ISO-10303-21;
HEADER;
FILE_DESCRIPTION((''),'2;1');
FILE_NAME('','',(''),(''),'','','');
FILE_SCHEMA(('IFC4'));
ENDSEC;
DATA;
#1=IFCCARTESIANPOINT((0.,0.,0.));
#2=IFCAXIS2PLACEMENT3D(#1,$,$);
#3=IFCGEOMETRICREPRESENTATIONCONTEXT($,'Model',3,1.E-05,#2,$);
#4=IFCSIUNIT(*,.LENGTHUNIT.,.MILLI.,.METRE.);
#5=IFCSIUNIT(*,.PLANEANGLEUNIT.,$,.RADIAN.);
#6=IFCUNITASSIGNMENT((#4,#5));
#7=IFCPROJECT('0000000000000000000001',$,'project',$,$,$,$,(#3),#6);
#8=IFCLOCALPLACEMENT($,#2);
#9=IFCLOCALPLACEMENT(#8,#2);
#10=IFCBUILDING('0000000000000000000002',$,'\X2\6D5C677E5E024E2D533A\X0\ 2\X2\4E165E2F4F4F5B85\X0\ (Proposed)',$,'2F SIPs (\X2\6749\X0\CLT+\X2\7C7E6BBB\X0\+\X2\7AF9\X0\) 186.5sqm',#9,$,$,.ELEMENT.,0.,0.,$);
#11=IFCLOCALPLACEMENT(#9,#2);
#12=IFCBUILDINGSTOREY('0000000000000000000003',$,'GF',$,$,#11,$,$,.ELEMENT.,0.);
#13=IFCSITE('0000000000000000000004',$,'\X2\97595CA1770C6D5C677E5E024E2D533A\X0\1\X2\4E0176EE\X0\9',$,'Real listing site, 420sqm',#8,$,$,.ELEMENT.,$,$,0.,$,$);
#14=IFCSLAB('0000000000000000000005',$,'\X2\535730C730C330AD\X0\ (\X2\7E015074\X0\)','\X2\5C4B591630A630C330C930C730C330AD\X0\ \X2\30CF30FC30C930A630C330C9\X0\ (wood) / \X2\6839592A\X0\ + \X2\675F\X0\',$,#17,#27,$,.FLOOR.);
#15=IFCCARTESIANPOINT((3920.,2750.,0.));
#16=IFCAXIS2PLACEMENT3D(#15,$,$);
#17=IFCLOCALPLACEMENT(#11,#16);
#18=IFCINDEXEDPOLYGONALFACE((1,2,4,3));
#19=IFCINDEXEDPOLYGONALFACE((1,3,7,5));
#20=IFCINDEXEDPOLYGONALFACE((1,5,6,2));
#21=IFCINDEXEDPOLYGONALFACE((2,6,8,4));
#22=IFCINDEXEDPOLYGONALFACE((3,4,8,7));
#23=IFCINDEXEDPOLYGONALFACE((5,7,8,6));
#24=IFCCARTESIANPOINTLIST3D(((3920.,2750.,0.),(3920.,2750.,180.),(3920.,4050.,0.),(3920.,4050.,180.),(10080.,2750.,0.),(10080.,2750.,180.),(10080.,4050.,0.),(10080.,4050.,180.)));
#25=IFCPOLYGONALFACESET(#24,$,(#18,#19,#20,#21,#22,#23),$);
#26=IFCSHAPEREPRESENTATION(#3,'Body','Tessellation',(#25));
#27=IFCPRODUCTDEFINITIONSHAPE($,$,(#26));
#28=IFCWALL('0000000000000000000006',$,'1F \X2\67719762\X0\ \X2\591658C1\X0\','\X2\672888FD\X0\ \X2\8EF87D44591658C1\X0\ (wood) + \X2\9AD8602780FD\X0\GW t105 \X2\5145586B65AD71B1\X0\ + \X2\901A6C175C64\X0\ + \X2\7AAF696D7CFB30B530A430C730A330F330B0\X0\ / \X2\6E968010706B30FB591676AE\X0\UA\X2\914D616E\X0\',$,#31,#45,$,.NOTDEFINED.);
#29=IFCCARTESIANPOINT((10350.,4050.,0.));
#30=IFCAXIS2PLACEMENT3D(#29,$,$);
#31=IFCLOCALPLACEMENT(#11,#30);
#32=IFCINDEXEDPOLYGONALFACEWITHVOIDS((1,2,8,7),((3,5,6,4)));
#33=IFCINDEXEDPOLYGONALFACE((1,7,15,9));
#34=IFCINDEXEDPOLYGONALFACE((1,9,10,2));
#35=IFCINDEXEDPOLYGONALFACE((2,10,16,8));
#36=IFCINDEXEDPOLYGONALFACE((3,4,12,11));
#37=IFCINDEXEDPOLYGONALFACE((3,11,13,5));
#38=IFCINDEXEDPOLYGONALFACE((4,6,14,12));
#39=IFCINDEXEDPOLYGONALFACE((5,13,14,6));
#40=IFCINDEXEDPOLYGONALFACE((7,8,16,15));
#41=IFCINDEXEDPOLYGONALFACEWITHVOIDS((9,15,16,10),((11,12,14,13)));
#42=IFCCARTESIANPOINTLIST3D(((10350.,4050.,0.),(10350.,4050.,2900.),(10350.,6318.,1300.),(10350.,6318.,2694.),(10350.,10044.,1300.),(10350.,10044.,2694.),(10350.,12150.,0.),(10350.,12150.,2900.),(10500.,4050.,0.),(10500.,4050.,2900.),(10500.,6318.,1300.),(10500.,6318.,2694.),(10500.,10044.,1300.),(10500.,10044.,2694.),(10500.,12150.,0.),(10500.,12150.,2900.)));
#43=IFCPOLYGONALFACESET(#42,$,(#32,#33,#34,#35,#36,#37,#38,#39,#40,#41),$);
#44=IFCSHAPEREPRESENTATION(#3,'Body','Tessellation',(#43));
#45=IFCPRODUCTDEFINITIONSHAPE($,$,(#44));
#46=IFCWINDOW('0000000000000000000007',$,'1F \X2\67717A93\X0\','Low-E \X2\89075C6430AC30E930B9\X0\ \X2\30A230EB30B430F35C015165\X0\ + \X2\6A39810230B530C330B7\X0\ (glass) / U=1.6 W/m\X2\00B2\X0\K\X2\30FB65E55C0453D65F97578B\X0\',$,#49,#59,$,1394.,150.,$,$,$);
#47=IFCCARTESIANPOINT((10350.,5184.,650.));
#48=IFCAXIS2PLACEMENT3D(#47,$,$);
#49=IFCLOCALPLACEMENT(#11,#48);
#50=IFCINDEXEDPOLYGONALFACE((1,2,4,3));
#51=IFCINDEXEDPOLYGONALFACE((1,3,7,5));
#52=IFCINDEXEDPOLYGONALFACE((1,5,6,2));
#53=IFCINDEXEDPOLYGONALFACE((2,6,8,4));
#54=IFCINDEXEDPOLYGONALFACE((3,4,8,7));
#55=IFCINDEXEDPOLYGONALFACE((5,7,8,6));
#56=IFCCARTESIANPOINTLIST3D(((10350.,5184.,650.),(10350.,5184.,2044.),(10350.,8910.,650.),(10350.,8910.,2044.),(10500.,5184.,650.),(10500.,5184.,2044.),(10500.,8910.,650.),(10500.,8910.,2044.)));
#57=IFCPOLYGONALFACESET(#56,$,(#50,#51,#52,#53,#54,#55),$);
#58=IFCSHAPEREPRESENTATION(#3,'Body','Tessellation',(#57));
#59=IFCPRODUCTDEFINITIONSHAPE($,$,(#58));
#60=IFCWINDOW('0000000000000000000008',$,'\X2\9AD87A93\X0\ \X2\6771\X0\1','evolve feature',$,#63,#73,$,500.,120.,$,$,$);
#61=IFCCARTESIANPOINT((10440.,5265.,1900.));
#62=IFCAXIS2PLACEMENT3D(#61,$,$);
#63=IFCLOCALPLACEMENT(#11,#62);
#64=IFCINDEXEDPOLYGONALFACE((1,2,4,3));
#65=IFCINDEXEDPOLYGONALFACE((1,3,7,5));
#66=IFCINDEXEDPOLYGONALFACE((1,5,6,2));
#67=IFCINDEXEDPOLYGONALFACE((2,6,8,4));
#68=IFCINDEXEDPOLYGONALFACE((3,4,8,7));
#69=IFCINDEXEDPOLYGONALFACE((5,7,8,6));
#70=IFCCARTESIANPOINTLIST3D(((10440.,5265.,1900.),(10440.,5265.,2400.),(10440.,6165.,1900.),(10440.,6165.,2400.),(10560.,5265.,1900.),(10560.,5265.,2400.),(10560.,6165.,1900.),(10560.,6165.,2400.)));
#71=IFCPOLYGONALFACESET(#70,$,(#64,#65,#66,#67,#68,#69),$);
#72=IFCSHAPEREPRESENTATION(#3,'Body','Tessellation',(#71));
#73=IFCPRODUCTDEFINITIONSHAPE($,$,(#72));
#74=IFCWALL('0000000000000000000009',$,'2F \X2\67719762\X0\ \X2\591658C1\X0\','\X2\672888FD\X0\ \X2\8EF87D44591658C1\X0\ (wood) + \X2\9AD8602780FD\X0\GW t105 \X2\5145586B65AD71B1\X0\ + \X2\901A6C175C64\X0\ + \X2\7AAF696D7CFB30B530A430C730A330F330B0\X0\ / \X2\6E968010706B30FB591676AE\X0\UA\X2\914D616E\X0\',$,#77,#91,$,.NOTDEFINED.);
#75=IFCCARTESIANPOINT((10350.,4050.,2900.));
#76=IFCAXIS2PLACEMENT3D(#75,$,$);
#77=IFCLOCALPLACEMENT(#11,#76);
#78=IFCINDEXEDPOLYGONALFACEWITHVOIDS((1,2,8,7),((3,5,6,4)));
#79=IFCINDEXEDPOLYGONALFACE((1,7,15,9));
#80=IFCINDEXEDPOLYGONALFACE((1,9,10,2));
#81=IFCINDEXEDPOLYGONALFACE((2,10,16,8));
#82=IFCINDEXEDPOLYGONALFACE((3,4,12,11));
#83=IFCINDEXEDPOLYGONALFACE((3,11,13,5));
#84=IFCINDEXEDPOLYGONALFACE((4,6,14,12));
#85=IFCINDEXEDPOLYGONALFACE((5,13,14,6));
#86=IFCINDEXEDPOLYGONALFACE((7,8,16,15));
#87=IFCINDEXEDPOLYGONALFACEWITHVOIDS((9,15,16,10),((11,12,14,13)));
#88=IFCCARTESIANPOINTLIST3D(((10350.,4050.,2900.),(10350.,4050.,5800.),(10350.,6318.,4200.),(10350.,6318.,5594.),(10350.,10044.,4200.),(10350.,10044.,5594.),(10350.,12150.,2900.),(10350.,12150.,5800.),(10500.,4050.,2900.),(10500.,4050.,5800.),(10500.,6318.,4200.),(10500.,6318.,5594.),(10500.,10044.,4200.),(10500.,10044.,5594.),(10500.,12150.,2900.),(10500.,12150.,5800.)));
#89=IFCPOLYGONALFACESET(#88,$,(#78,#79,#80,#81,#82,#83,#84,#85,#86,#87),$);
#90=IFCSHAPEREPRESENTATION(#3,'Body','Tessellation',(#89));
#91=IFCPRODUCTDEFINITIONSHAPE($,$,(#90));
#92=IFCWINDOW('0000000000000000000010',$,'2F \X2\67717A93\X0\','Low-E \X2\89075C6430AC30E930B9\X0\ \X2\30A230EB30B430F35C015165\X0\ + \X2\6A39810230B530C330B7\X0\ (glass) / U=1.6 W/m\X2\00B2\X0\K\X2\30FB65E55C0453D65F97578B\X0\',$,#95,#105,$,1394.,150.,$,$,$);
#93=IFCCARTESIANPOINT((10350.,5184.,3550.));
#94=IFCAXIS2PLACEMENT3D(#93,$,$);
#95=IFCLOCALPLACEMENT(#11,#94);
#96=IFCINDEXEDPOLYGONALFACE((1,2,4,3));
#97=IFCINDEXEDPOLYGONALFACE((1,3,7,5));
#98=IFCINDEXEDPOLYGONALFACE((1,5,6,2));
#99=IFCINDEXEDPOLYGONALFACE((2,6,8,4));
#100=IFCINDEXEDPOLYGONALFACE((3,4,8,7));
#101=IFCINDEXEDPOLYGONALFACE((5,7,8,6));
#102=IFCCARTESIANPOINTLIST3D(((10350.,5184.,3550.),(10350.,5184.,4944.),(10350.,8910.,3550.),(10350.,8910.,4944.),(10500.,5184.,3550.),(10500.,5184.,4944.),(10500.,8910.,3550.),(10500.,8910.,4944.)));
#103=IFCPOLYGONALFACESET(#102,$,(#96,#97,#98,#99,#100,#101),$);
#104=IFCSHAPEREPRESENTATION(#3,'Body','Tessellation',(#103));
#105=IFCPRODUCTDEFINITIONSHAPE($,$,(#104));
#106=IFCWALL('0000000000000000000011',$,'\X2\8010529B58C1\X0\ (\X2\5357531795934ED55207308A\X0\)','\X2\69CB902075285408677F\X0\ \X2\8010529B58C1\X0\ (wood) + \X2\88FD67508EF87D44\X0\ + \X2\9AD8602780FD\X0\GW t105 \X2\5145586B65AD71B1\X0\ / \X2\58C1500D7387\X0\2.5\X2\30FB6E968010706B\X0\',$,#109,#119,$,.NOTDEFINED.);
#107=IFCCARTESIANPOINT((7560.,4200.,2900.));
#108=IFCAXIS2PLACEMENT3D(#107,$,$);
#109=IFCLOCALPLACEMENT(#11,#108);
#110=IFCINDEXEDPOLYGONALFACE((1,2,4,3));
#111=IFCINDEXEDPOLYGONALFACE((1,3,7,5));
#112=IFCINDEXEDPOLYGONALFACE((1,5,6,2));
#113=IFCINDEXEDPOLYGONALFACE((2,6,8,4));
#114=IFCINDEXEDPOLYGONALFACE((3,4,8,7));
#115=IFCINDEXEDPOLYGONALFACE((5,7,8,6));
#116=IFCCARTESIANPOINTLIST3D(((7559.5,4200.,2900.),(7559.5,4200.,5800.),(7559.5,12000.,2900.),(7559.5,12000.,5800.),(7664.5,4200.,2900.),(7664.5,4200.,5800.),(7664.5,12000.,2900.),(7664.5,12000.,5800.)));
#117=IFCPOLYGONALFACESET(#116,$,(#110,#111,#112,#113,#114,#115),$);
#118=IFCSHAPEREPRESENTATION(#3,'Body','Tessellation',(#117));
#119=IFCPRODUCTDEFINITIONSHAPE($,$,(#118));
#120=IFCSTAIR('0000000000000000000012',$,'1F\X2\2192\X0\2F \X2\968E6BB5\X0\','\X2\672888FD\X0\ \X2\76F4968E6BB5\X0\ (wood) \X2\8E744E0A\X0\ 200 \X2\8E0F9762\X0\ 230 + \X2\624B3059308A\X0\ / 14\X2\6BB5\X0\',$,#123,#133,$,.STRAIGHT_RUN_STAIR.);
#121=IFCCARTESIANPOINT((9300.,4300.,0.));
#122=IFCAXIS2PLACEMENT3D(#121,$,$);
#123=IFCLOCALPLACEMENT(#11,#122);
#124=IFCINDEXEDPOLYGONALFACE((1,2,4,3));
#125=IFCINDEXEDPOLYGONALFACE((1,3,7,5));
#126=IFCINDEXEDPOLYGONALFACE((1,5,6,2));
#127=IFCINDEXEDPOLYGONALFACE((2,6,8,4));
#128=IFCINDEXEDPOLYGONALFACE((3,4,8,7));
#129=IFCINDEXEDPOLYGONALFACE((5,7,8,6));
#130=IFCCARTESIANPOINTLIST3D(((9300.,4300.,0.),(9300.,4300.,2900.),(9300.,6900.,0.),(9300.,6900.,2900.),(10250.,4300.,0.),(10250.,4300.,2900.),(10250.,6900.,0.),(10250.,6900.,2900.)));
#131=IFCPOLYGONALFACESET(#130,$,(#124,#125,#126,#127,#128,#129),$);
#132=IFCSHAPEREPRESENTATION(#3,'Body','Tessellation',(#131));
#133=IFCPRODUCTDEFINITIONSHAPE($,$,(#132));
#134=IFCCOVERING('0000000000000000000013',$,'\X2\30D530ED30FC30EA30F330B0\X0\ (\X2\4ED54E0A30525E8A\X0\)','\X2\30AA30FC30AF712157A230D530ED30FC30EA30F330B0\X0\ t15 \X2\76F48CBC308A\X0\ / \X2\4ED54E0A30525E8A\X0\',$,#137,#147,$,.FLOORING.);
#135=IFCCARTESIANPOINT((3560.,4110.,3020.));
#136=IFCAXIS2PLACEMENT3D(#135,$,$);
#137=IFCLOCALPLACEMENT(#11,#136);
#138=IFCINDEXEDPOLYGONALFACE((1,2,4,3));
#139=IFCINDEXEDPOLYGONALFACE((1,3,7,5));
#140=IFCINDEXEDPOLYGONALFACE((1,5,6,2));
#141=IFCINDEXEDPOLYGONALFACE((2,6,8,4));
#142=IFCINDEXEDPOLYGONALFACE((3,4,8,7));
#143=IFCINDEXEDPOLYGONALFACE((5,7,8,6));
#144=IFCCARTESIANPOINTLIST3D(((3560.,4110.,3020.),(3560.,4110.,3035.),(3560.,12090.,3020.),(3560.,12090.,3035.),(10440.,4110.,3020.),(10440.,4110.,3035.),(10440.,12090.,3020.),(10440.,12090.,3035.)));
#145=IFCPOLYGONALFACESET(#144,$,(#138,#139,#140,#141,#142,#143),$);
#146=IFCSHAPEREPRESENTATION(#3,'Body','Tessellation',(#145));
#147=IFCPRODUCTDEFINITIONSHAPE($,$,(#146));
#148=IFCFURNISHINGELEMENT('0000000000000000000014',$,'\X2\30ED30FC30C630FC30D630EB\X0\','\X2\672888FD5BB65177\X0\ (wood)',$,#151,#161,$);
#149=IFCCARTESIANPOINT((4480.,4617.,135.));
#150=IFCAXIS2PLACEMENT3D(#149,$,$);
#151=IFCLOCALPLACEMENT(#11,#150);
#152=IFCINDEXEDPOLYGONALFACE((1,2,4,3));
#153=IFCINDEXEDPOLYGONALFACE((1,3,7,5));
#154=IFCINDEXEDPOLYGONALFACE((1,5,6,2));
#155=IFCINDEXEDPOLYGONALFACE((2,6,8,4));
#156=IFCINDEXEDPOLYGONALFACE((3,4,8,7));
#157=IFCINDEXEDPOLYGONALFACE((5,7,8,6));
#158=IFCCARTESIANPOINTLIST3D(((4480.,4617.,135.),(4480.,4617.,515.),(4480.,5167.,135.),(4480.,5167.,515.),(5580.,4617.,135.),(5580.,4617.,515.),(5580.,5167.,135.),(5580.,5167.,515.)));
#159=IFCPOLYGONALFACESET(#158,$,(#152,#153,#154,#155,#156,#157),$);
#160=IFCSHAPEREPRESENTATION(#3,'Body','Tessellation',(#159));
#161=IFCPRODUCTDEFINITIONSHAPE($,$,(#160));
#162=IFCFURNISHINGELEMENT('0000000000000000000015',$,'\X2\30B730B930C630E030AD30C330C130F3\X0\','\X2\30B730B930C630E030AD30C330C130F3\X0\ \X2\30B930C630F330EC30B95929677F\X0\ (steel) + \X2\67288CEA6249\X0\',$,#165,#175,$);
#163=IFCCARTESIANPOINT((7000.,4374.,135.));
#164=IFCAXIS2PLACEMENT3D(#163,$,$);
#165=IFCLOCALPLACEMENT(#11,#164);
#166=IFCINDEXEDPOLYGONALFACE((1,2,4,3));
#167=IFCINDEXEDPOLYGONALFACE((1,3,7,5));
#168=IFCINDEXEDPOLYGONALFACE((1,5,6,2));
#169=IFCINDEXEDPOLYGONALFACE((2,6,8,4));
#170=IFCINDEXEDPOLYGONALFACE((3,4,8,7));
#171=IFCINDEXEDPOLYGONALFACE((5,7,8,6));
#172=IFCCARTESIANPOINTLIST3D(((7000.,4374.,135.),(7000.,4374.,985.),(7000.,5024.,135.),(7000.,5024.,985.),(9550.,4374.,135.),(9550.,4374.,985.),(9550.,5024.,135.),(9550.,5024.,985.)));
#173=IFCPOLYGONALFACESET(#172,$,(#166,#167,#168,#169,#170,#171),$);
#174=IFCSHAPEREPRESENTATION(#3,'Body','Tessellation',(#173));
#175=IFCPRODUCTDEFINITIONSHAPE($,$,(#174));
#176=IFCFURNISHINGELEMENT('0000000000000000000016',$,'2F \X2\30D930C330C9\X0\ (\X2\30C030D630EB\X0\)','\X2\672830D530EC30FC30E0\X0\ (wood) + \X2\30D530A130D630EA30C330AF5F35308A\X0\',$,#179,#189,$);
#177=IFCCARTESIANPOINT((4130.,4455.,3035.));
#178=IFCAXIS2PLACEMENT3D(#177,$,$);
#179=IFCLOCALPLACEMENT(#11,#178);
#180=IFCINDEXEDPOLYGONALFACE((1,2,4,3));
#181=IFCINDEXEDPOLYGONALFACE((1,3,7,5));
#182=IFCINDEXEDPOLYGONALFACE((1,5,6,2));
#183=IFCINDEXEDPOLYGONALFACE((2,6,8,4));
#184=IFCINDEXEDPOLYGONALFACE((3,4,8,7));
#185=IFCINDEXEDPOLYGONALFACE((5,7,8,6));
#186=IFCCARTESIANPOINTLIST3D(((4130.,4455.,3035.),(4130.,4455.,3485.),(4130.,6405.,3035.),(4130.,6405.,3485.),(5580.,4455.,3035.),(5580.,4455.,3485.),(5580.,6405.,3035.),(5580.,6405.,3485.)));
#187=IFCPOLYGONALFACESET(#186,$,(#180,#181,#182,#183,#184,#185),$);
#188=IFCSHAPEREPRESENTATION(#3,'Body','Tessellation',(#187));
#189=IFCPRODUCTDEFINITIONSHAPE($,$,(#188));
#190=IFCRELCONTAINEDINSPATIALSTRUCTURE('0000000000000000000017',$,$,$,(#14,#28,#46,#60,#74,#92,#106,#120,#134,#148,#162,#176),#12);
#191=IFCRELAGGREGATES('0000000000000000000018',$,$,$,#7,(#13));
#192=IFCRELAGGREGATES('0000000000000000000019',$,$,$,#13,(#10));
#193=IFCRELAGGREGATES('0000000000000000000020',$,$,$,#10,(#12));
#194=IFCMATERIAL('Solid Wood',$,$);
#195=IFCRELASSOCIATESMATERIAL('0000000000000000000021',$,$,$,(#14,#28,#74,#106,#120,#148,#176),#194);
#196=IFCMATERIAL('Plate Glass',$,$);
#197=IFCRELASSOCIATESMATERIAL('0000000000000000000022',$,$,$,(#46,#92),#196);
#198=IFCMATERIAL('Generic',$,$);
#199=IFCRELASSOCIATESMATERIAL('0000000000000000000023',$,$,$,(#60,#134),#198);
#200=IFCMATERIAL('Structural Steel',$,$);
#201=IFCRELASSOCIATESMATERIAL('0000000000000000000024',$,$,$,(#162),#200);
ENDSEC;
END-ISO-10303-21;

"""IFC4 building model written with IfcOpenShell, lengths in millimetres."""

from ifc_helpers import new_model, si_unit, frame, frame_2d, origin, place, context, project, spatial, rectangle, extrude, material, element, fill, save


model = new_model("IFC4")

# Units and contexts
model_context = context("Model", 3, precision=1e-05, world=origin())
ifc_project = project(units=[si_unit("LENGTHUNIT", "METRE", prefix="MILLI"), si_unit("PLANEANGLEUNIT", "RADIAN")], contexts=[model_context])

# Site, building, storey
site_placement = place(None, origin())
site = spatial("IfcSite", under=ifc_project, at=site_placement, Name="静岡県浜松市中区1丁目9", ObjectType="Real listing site, 420sqm", CompositionType="ELEMENT", RefElevation=0.0)
building_placement = place(site_placement, origin())
building = spatial("IfcBuilding", under=site, at=building_placement, Name="浜松市中区 2世帯住宅 (Proposed)", ObjectType="2F SIPs (杉CLT+籾殻+竹) 186.5sqm", CompositionType="ELEMENT", ElevationOfRefHeight=0.0, ElevationOfTerrain=0.0)
storey_placement = place(building_placement, origin())
storey = spatial("IfcBuildingStorey", under=building, at=storey_placement, Name="GF", CompositionType="ELEMENT", Elevation=0.0)

# Slab
ifc_material_1 = material(Name="Solid Wood")
slab_placement = place(storey_placement, frame((3920.0, 2750.0, 0.0)))
element("IfcSlab", 1, at=slab_placement, inside=storey, material=ifc_material_1, Name="南デッキ (縁側)", Description="屋外ウッドデッキ ハードウッド (wood) / 根太 + 束", PredefinedType="FLOOR", context=model_context, shape_type="SweptSolid", body=[
    extrude(rectangle(XDim=6160.0, YDim=1300.0, at=frame_2d((3080.0, 650.0))), frame((3920.0, 2750.0, 0.0)), (0.0, 0.0, 1.0), 180.0),
])

# Wall, openings, windows
wall_1_placement = place(storey_placement, frame((10350.0, 4050.0, 0.0)))
wall_1 = element("IfcWall", 2, at=wall_1_placement, inside=storey, material=ifc_material_1, Name="1F 東面 外壁", Description="木製 軸組外壁 (wood) + 高性能GW t105 充填断熱 + 通気層 + 窯業系サイディング / 準耐火・外皮UA配慮", PredefinedType="NOTDEFINED", context=model_context, shape_type="SweptSolid", body=[
    extrude(rectangle(XDim=150.0, YDim=8100.0, at=frame_2d((75.0, 4050.0))), frame((10350.0, 4050.0, 0.0)), (0.0, 0.0, 1.0), 2900.0),
])
opening_1_placement = place(storey_placement, frame((10350.0, 5184.0, 650.0)))
opening_1 = element("IfcOpeningElement", 3, at=opening_1_placement, cuts=wall_1, PredefinedType="NOTDEFINED", context=model_context, shape_type="SweptSolid", body=[
    extrude(rectangle(XDim=150.0, YDim=3726.0, at=frame_2d((75.0, 1863.0))), frame((10350.0, 5184.0, 650.0)), (0.0, 0.0, 1.0), 1394.0),
])
opening_2_placement = place(storey_placement, frame((10440.0, 5265.0, 1900.0)))
opening_2 = element("IfcOpeningElement", 4, at=opening_2_placement, cuts=wall_1, PredefinedType="NOTDEFINED", context=model_context, shape_type="SweptSolid", body=[
    extrude(rectangle(XDim=120.0, YDim=900.0, at=frame_2d((60.0, 450.0))), frame((10440.0, 5265.0, 1900.0)), (0.0, 0.0, 1.0), 500.0),
])
ifc_material_2 = material(Name="Plate Glass")
window_1_placement = place(storey_placement, frame((10350.0, 5184.0, 650.0)))
window_1 = element("IfcWindow", 5, at=window_1_placement, inside=storey, material=ifc_material_2, Name="1F 東窓", Description="Low-E 複層ガラス アルゴン封入 + 樹脂サッシ (glass) / U=1.6 W/m²K・日射取得型", OverallHeight=1394.0, OverallWidth=150.0, context=model_context, shape_type="SweptSolid", body=[
    extrude(rectangle(XDim=150.0, YDim=3726.0, at=frame_2d((75.0, 1863.0))), frame((10350.0, 5184.0, 650.0)), (0.0, 0.0, 1.0), 1394.0),
])
fill(opening_1, window_1)
ifc_material_3 = material(Name="Generic")
window_2_placement = place(storey_placement, frame((10440.0, 5265.0, 1900.0)))
window_2 = element("IfcWindow", 6, at=window_2_placement, inside=storey, material=ifc_material_3, Name="高窓 東1", Description="evolve feature", OverallHeight=500.0, OverallWidth=120.0, context=model_context, shape_type="SweptSolid", body=[
    extrude(rectangle(XDim=120.0, YDim=900.0, at=frame_2d((60.0, 450.0))), frame((10440.0, 5265.0, 1900.0)), (0.0, 0.0, 1.0), 500.0),
])
fill(opening_2, window_2)

# Wall, opening, window
wall_2_placement = place(storey_placement, frame((10350.0, 4050.0, 2900.0)))
wall_2 = element("IfcWall", 7, at=wall_2_placement, inside=storey, material=ifc_material_1, Name="2F 東面 外壁", Description="木製 軸組外壁 (wood) + 高性能GW t105 充填断熱 + 通気層 + 窯業系サイディング / 準耐火・外皮UA配慮", PredefinedType="NOTDEFINED", context=model_context, shape_type="SweptSolid", body=[
    extrude(rectangle(XDim=150.0, YDim=8100.0, at=frame_2d((75.0, 4050.0))), frame((10350.0, 4050.0, 2900.0)), (0.0, 0.0, 1.0), 2900.0),
])
opening_3_placement = place(storey_placement, frame((10350.0, 5184.0, 3550.0)))
opening_3 = element("IfcOpeningElement", 8, at=opening_3_placement, cuts=wall_2, PredefinedType="NOTDEFINED", context=model_context, shape_type="SweptSolid", body=[
    extrude(rectangle(XDim=150.0, YDim=3726.0, at=frame_2d((75.0, 1863.0))), frame((10350.0, 5184.0, 3550.0)), (0.0, 0.0, 1.0), 1394.0),
])
window_3_placement = place(storey_placement, frame((10350.0, 5184.0, 3550.0)))
window_3 = element("IfcWindow", 9, at=window_3_placement, inside=storey, material=ifc_material_2, Name="2F 東窓", Description="Low-E 複層ガラス アルゴン封入 + 樹脂サッシ (glass) / U=1.6 W/m²K・日射取得型", OverallHeight=1394.0, OverallWidth=150.0, context=model_context, shape_type="SweptSolid", body=[
    extrude(rectangle(XDim=150.0, YDim=3726.0, at=frame_2d((75.0, 1863.0))), frame((10350.0, 5184.0, 3550.0)), (0.0, 0.0, 1.0), 1394.0),
])
fill(opening_3, window_3)

# Wall
wall_3_placement = place(storey_placement, frame((7560.0, 4200.0, 2900.0)))
element("IfcWall", 10, at=wall_3_placement, inside=storey, material=ifc_material_1, Name="耐力壁 (南北間仕切り)", Description="構造用合板 耐力壁 (wood) + 製材軸組 + 高性能GW t105 充填断熱 / 壁倍率2.5・準耐火", PredefinedType="NOTDEFINED", context=model_context, shape_type="SweptSolid", body=[
    extrude(rectangle(XDim=105.0, YDim=7800.0, at=frame_2d((52.0, 3900.0))), frame((7560.0, 4200.0, 2900.0)), (0.0, 0.0, 1.0), 2900.0),
])

# Stair
stair_placement = place(storey_placement, frame((9300.0, 4300.0, 0.0)))
element("IfcStair", 11, at=stair_placement, inside=storey, material=ifc_material_1, Name="1F→2F 階段", Description="木製 直階段 (wood) 蹴上 200 踏面 230 + 手すり / 14段", PredefinedType="STRAIGHT_RUN_STAIR", context=model_context, shape_type="SweptSolid", body=[
    extrude(rectangle(XDim=950.0, YDim=2600.0, at=frame_2d((475.0, 1300.0))), frame((9300.0, 4300.0, 0.0)), (0.0, 0.0, 1.0), 2900.0),
])

# Covering
covering_placement = place(storey_placement, frame((3560.0, 4110.0, 3020.0)))
element("IfcCovering", 12, at=covering_placement, inside=storey, material=ifc_material_3, Name="フローリング (仕上げ床)", Description="オーク無垢フローリング t15 直貼り / 仕上げ床", PredefinedType="FLOORING", context=model_context, shape_type="SweptSolid", body=[
    extrude(rectangle(XDim=6880.0, YDim=7980.0, at=frame_2d((3440.0, 3990.0))), frame((3560.0, 4110.0, 3020.0)), (0.0, 0.0, 1.0), 15.0),
])

# Furnishing elements
furnishing_1_placement = place(storey_placement, frame((4480.0, 4617.0, 135.0)))
element("IfcFurnishingElement", 13, at=furnishing_1_placement, inside=storey, material=ifc_material_1, Name="ローテーブル", Description="木製家具 (wood)", context=model_context, shape_type="SweptSolid", body=[
    extrude(rectangle(XDim=1100.0, YDim=550.0, at=frame_2d((550.0, 275.0))), frame((4480.0, 4617.0, 135.0)), (0.0, 0.0, 1.0), 380.0),
])
ifc_material_4 = material(Name="Structural Steel")
furnishing_2_placement = place(storey_placement, frame((7000.0, 4374.0, 135.0)))
element("IfcFurnishingElement", 14, at=furnishing_2_placement, inside=storey, material=ifc_material_4, Name="システムキッチン", Description="システムキッチン ステンレス天板 (steel) + 木質扉", context=model_context, shape_type="SweptSolid", body=[
    extrude(rectangle(XDim=2550.0, YDim=650.0, at=frame_2d((1275.0, 325.0))), frame((7000.0, 4374.0, 135.0)), (0.0, 0.0, 1.0), 850.0),
])
furnishing_3_placement = place(storey_placement, frame((4130.0, 4455.0, 3035.0)))
element("IfcFurnishingElement", 15, at=furnishing_3_placement, inside=storey, material=ifc_material_1, Name="2F ベッド (ダブル)", Description="木フレーム (wood) + ファブリック張り", context=model_context, shape_type="SweptSolid", body=[
    extrude(rectangle(XDim=1450.0, YDim=1950.0, at=frame_2d((725.0, 975.0))), frame((4130.0, 4455.0, 3035.0)), (0.0, 0.0, 1.0), 450.0),
])

save(model, "model.ifc")
